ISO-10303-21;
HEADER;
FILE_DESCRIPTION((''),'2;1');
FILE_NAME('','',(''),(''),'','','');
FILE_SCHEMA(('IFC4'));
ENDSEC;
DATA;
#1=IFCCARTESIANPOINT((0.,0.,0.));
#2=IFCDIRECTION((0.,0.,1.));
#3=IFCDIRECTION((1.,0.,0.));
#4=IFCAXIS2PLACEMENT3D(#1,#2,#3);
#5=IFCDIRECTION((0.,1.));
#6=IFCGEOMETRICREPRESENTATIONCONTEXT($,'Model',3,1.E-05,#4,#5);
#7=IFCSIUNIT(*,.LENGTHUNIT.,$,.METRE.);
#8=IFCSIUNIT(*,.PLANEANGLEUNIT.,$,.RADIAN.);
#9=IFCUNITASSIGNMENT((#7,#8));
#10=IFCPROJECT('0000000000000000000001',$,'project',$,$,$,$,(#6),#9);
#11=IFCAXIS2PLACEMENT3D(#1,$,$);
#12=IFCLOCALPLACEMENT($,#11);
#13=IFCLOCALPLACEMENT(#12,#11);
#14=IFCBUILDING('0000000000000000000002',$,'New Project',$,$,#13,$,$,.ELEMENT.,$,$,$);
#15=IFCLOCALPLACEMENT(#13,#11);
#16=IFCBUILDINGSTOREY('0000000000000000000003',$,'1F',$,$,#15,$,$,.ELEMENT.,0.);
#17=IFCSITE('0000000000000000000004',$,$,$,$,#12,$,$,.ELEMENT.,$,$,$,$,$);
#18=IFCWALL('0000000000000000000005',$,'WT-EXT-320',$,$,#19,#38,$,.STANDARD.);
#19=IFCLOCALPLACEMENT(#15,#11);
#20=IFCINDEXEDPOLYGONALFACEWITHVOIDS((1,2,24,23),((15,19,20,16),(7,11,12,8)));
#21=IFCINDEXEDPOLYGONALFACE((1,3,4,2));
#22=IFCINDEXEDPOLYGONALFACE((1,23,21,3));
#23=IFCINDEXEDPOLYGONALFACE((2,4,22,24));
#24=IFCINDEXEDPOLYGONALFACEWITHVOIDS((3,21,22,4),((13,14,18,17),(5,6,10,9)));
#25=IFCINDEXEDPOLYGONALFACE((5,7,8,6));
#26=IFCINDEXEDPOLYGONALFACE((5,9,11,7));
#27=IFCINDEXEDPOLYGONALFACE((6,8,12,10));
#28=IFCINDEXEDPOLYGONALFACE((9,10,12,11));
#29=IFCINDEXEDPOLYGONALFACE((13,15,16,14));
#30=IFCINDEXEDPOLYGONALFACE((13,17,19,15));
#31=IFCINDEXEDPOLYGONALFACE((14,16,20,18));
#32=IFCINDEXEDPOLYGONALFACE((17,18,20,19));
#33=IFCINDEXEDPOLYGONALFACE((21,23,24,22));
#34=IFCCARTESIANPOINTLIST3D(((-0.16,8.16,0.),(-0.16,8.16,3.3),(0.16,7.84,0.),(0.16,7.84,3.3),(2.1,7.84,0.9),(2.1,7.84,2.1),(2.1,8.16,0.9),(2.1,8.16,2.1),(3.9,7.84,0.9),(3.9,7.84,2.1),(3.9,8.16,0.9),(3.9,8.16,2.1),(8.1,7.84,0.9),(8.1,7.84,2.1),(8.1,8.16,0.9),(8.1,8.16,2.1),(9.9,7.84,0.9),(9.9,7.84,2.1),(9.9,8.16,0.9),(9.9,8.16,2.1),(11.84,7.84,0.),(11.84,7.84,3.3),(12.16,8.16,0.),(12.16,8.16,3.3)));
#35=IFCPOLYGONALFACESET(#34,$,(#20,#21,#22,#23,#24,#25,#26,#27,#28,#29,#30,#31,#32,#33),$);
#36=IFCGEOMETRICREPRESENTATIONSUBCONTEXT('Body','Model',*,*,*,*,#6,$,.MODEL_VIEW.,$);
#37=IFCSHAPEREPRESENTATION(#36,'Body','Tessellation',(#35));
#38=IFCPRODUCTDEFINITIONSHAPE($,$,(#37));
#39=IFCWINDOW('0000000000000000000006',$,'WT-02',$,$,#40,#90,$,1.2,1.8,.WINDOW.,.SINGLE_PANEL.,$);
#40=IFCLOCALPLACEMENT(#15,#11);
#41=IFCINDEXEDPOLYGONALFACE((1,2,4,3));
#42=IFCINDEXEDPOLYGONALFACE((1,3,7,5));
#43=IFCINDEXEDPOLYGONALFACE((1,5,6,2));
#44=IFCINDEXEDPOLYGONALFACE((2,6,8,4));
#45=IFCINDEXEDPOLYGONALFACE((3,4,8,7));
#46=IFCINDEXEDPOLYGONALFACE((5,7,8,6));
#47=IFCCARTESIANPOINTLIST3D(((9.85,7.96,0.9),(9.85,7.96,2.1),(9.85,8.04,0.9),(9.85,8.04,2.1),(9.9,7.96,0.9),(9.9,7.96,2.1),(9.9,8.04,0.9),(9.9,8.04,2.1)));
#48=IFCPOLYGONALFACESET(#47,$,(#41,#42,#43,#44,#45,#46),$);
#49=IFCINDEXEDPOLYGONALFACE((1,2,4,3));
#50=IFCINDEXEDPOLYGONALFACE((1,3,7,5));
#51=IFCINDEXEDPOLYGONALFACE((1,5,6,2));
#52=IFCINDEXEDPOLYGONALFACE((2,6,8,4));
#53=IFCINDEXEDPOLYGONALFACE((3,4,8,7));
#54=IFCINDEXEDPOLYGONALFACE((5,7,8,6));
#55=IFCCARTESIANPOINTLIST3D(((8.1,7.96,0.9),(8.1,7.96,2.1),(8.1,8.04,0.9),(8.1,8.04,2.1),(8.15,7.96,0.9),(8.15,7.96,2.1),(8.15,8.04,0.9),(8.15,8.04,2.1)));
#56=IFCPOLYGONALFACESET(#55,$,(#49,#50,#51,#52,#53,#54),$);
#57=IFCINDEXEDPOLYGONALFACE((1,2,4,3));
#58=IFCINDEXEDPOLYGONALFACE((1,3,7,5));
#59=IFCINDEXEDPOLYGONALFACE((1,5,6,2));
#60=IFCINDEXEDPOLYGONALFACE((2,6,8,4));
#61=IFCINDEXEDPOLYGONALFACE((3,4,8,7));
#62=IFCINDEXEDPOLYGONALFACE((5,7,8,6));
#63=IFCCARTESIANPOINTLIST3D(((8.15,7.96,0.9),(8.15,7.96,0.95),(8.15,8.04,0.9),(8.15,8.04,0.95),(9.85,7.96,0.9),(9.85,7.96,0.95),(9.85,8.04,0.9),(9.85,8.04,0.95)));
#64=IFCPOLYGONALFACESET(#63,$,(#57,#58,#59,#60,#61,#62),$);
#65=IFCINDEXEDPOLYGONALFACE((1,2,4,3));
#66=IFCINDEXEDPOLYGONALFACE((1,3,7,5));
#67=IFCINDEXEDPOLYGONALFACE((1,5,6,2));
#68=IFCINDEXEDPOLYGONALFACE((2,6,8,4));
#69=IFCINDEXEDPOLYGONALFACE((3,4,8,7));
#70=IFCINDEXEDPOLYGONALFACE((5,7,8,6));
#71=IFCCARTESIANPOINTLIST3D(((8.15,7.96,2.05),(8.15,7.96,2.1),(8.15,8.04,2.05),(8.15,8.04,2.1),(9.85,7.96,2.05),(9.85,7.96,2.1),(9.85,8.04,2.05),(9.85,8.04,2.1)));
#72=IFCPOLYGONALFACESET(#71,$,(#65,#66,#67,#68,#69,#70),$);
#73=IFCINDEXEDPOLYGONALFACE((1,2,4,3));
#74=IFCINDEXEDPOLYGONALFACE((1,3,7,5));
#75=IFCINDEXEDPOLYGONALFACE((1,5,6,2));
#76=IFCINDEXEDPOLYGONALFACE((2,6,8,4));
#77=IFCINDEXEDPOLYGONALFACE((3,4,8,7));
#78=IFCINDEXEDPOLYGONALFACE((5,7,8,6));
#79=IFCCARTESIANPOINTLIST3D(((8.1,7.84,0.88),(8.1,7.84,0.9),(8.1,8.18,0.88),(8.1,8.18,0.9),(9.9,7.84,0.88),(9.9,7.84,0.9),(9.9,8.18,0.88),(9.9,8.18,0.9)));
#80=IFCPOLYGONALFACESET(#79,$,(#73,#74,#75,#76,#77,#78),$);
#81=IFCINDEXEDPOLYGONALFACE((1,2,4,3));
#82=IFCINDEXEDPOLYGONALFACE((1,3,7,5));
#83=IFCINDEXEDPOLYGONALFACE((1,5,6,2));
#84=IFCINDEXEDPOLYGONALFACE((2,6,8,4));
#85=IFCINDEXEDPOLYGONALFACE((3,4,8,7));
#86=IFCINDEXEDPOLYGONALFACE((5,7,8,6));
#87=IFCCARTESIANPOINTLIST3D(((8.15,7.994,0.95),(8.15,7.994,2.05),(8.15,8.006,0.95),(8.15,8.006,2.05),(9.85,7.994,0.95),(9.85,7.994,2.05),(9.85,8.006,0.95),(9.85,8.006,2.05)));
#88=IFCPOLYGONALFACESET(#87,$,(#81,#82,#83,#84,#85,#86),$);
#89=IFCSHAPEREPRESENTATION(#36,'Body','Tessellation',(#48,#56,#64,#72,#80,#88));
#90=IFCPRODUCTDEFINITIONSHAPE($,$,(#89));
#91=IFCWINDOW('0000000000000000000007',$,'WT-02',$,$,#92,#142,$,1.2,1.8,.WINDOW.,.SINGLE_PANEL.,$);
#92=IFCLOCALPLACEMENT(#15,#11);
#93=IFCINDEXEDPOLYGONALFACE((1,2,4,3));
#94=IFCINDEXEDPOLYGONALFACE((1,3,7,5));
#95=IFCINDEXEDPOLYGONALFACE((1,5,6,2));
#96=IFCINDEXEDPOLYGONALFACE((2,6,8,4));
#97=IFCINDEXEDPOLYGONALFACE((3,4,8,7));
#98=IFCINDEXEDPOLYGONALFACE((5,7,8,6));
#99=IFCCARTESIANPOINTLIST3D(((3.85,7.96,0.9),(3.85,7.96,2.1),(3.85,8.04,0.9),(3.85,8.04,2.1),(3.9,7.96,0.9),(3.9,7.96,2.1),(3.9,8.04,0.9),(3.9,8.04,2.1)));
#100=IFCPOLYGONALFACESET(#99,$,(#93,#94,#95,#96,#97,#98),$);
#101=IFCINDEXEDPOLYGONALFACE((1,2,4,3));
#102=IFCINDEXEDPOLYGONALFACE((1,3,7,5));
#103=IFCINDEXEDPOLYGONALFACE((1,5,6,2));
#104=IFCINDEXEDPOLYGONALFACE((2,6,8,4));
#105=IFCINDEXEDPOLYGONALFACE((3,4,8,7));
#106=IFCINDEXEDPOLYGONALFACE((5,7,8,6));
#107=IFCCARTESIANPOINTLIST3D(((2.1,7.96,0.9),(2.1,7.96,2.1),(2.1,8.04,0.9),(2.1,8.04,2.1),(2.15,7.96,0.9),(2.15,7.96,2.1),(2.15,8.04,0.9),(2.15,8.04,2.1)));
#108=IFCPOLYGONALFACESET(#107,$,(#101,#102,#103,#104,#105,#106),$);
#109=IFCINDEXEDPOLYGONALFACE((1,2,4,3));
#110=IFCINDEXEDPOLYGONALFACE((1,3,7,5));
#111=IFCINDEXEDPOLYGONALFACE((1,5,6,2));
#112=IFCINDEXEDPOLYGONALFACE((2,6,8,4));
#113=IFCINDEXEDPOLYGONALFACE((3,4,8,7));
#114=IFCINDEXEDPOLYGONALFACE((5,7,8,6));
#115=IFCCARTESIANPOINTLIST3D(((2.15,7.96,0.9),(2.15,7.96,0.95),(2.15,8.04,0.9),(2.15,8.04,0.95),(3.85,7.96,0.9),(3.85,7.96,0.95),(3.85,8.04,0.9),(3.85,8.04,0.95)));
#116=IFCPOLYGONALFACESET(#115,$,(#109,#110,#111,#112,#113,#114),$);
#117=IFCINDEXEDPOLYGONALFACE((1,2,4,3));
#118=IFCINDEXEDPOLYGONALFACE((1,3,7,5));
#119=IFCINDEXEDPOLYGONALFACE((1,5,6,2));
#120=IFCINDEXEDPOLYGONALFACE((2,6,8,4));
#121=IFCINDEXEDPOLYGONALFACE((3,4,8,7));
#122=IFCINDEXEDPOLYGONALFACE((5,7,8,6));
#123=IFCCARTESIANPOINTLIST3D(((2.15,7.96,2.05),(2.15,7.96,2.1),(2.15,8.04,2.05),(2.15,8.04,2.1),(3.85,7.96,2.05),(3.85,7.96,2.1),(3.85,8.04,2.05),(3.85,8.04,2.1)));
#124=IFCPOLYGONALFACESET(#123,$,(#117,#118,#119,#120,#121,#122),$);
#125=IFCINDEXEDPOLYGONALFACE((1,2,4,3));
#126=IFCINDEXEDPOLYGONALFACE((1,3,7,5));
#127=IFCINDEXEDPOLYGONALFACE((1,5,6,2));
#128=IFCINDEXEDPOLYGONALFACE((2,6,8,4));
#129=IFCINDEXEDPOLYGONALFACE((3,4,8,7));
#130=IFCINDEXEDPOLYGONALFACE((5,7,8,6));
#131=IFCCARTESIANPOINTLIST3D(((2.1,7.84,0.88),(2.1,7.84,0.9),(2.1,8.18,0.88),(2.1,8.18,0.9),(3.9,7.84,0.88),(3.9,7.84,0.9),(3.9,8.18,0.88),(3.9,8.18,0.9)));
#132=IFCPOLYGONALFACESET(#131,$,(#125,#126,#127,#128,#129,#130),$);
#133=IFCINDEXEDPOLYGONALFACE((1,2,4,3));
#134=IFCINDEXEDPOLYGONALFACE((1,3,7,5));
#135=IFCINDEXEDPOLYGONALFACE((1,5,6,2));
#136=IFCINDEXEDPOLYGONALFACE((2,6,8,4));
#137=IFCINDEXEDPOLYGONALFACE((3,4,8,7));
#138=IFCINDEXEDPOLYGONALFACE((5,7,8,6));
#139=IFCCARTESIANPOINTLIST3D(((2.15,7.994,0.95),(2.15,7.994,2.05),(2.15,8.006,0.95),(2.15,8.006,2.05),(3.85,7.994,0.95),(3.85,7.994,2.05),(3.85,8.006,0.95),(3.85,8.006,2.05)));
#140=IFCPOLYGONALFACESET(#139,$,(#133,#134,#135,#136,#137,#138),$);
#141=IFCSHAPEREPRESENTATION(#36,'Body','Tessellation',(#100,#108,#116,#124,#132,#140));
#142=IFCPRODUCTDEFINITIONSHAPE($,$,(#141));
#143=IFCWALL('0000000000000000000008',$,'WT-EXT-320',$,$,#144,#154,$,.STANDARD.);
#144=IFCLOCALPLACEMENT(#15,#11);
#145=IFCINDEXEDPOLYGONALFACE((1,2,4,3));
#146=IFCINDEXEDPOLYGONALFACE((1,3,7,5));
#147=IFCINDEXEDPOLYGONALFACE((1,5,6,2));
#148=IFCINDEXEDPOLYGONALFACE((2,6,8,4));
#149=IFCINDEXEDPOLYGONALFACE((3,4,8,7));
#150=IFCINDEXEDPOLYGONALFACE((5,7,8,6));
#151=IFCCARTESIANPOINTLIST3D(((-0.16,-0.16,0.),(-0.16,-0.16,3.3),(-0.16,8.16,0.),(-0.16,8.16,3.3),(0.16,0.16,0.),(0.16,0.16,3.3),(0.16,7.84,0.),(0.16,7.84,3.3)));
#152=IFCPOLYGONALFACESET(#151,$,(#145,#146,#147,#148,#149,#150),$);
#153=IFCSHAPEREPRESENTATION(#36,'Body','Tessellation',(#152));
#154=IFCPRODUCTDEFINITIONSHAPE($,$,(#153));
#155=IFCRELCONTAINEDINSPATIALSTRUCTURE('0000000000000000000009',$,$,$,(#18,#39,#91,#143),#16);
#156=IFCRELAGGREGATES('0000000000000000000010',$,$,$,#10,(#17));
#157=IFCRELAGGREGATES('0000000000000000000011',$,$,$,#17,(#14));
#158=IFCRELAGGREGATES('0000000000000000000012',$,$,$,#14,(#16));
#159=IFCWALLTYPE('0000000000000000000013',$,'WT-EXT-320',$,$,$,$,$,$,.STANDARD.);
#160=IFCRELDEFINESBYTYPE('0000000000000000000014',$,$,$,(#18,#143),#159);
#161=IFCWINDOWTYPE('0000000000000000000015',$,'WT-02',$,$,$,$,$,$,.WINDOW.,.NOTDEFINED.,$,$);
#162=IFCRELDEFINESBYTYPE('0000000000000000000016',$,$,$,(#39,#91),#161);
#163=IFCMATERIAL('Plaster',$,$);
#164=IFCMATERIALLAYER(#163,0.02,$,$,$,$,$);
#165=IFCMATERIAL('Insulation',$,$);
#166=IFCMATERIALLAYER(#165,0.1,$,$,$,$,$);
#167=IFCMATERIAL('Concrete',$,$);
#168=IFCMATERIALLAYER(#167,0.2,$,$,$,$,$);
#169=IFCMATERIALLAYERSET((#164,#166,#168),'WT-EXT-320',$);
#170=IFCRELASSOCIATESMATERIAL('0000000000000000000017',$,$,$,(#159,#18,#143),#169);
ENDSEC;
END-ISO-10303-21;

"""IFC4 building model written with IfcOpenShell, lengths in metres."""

from ifc_helpers import new_model, si_unit, direction, frame, frame_2d, origin, origin_with_axes, place, context, subcontext, project, spatial, polyline, rectangle, outline, extrude, material, layer, layer_set, layer_usage, type_object, element, fill, save


model = new_model("IFC4")

# Units and contexts
model_context = context("Model", 3, precision=1e-05, world=origin_with_axes(), true_north=direction((0.0, 1.0)))
body_context = subcontext(model_context, "Body", "Model", "MODEL_VIEW")
ifc_project = project(units=[si_unit("LENGTHUNIT", "METRE"), si_unit("PLANEANGLEUNIT", "RADIAN")], contexts=[model_context])

# Site, building, storey
site_placement = place(None, origin())
site = spatial("IfcSite", under=ifc_project, at=site_placement, CompositionType="ELEMENT")
building_placement = place(site_placement, origin())
building = spatial("IfcBuilding", under=site, at=building_placement, Name="New Project", CompositionType="ELEMENT")
storey_placement = place(building_placement, origin())
storey = spatial("IfcBuildingStorey", under=building, at=storey_placement, Name="1F", CompositionType="ELEMENT", Elevation=0.0)

# Shared definitions
ifc_material_1 = material(Name="Concrete")

# Shared definitions
ifc_material_2 = material(Name="Plaster")
ifc_layer_1 = layer(ifc_material_2, 0.02)
ifc_material_3 = material(Name="Insulation")
ifc_layer_2 = layer(ifc_material_3, 0.1)
ifc_layer_3 = layer(ifc_material_1, 0.2)
ifc_layer_set_1 = layer_set([ifc_layer_1, ifc_layer_2, ifc_layer_3], Name="WT-EXT-320")
ifc_layer_usage_1 = layer_usage(ifc_layer_set_1, "AXIS2", "NEGATIVE", 0.16)
wall_type_1 = type_object("IfcWallType", Name="WT-EXT-320", PredefinedType="STANDARD", material=ifc_layer_set_1)

# Wall, openings, windows
wall_1_placement = place(storey_placement, frame((12.0, 8.0, 0.0), z_axis=(0.0, 0.0, 1.0), x_axis=(-1.0, 0.0, 0.0)))
wall_1 = element("IfcWall", 1, at=wall_1_placement, inside=storey, type_object=wall_type_1, material=ifc_layer_usage_1, Name="WT-EXT-320", PredefinedType="STANDARD", context=body_context, shape_type="SweptSolid", body=[
    extrude(outline(polyline([(-0.16, -0.16), (12.16, -0.16), (11.84, 0.16), (0.16, 0.16), (-0.16, -0.16)])), origin(), (0.0, 0.0, 1.0), 3.3),
])
opening_1_placement = place(wall_1_placement, frame((2.1, 0.0, 0.9)))
opening_1 = element("IfcOpeningElement", 2, at=opening_1_placement, cuts=wall_1, PredefinedType="OPENING", context=body_context, shape_type="SweptSolid", body=[
    extrude(rectangle(XDim=1.8, YDim=0.42, at=frame_2d((0.9, 0.0))), origin(), (0.0, 0.0, 1.0), 1.2),
])
opening_2_placement = place(wall_1_placement, frame((8.1, 0.0, 0.9)))
opening_2 = element("IfcOpeningElement", 3, at=opening_2_placement, cuts=wall_1, PredefinedType="OPENING", context=body_context, shape_type="SweptSolid", body=[
    extrude(rectangle(XDim=1.8, YDim=0.42, at=frame_2d((0.9, 0.0))), origin(), (0.0, 0.0, 1.0), 1.2),
])
window_type_1 = type_object("IfcWindowType", Name="WT-02", PartitioningType="NOTDEFINED", PredefinedType="WINDOW")
window_1_placement = place(opening_1_placement, origin())
window_1 = element("IfcWindow", 4, at=window_1_placement, inside=storey, type_object=window_type_1, Name="WT-02", OverallHeight=1.2, OverallWidth=1.8, PartitioningType="SINGLE_PANEL", PredefinedType="WINDOW", context=body_context, shape_type="SweptSolid", body=[
    extrude(outline(polyline([(0.0, -0.04), (0.05, -0.04), (0.05, 0.04), (0.0, 0.04), (0.0, -0.04)])), origin(), (0.0, 0.0, 1.0), 1.2),
    extrude(outline(polyline([(1.75, -0.04), (1.8, -0.04), (1.8, 0.04), (1.75, 0.04), (1.75, -0.04)])), origin(), (0.0, 0.0, 1.0), 1.2),
    extrude(outline(polyline([(0.05, -0.04), (1.75, -0.04), (1.75, 0.04), (0.05, 0.04), (0.05, -0.04)])), origin(), (0.0, 0.0, 1.0), 0.05),
    extrude(outline(polyline([(0.05, -0.04), (1.75, -0.04), (1.75, 0.04), (0.05, 0.04), (0.05, -0.04)])), frame((0.0, 0.0, 1.15)), (0.0, 0.0, 1.0), 0.05),
    extrude(outline(polyline([(0.0, -0.18), (1.8, -0.18), (1.8, 0.16), (0.0, 0.16), (0.0, -0.18)])), frame((0.0, 0.0, -0.02)), (0.0, 0.0, 1.0), 0.02),
    extrude(outline(polyline([(0.05, -0.006), (1.75, -0.006), (1.75, 0.006), (0.05, 0.006), (0.05, -0.006)])), frame((0.0, 0.0, 0.05)), (0.0, 0.0, 1.0), 1.1),
])
fill(opening_1, window_1)
window_2_placement = place(opening_2_placement, origin())
window_2 = element("IfcWindow", 5, at=window_2_placement, inside=storey, type_object=window_type_1, Name="WT-02", OverallHeight=1.2, OverallWidth=1.8, PartitioningType="SINGLE_PANEL", PredefinedType="WINDOW", context=body_context, shape_type="SweptSolid", body=[
    extrude(outline(polyline([(0.0, -0.04), (0.05, -0.04), (0.05, 0.04), (0.0, 0.04), (0.0, -0.04)])), origin(), (0.0, 0.0, 1.0), 1.2),
    extrude(outline(polyline([(1.75, -0.04), (1.8, -0.04), (1.8, 0.04), (1.75, 0.04), (1.75, -0.04)])), origin(), (0.0, 0.0, 1.0), 1.2),
    extrude(outline(polyline([(0.05, -0.04), (1.75, -0.04), (1.75, 0.04), (0.05, 0.04), (0.05, -0.04)])), origin(), (0.0, 0.0, 1.0), 0.05),
    extrude(outline(polyline([(0.05, -0.04), (1.75, -0.04), (1.75, 0.04), (0.05, 0.04), (0.05, -0.04)])), frame((0.0, 0.0, 1.15)), (0.0, 0.0, 1.0), 0.05),
    extrude(outline(polyline([(0.0, -0.18), (1.8, -0.18), (1.8, 0.16), (0.0, 0.16), (0.0, -0.18)])), frame((0.0, 0.0, -0.02)), (0.0, 0.0, 1.0), 0.02),
    extrude(outline(polyline([(0.05, -0.006), (1.75, -0.006), (1.75, 0.006), (0.05, 0.006), (0.05, -0.006)])), frame((0.0, 0.0, 0.05)), (0.0, 0.0, 1.0), 1.1),
])
fill(opening_2, window_2)

# Wall
wall_2_placement = place(storey_placement, frame((0.0, 8.0, 0.0), z_axis=(0.0, 0.0, 1.0), x_axis=(0.0, -1.0, 0.0)))
element("IfcWall", 6, at=wall_2_placement, inside=storey, type_object=wall_type_1, material=ifc_layer_usage_1, Name="WT-EXT-320", PredefinedType="STANDARD", context=body_context, shape_type="SweptSolid", body=[
    extrude(outline(polyline([(-0.16, -0.16), (8.16, -0.16), (7.84, 0.16), (0.16, 0.16), (-0.16, -0.16)])), origin(), (0.0, 0.0, 1.0), 3.3),
])

save(model, "model.ifc")
